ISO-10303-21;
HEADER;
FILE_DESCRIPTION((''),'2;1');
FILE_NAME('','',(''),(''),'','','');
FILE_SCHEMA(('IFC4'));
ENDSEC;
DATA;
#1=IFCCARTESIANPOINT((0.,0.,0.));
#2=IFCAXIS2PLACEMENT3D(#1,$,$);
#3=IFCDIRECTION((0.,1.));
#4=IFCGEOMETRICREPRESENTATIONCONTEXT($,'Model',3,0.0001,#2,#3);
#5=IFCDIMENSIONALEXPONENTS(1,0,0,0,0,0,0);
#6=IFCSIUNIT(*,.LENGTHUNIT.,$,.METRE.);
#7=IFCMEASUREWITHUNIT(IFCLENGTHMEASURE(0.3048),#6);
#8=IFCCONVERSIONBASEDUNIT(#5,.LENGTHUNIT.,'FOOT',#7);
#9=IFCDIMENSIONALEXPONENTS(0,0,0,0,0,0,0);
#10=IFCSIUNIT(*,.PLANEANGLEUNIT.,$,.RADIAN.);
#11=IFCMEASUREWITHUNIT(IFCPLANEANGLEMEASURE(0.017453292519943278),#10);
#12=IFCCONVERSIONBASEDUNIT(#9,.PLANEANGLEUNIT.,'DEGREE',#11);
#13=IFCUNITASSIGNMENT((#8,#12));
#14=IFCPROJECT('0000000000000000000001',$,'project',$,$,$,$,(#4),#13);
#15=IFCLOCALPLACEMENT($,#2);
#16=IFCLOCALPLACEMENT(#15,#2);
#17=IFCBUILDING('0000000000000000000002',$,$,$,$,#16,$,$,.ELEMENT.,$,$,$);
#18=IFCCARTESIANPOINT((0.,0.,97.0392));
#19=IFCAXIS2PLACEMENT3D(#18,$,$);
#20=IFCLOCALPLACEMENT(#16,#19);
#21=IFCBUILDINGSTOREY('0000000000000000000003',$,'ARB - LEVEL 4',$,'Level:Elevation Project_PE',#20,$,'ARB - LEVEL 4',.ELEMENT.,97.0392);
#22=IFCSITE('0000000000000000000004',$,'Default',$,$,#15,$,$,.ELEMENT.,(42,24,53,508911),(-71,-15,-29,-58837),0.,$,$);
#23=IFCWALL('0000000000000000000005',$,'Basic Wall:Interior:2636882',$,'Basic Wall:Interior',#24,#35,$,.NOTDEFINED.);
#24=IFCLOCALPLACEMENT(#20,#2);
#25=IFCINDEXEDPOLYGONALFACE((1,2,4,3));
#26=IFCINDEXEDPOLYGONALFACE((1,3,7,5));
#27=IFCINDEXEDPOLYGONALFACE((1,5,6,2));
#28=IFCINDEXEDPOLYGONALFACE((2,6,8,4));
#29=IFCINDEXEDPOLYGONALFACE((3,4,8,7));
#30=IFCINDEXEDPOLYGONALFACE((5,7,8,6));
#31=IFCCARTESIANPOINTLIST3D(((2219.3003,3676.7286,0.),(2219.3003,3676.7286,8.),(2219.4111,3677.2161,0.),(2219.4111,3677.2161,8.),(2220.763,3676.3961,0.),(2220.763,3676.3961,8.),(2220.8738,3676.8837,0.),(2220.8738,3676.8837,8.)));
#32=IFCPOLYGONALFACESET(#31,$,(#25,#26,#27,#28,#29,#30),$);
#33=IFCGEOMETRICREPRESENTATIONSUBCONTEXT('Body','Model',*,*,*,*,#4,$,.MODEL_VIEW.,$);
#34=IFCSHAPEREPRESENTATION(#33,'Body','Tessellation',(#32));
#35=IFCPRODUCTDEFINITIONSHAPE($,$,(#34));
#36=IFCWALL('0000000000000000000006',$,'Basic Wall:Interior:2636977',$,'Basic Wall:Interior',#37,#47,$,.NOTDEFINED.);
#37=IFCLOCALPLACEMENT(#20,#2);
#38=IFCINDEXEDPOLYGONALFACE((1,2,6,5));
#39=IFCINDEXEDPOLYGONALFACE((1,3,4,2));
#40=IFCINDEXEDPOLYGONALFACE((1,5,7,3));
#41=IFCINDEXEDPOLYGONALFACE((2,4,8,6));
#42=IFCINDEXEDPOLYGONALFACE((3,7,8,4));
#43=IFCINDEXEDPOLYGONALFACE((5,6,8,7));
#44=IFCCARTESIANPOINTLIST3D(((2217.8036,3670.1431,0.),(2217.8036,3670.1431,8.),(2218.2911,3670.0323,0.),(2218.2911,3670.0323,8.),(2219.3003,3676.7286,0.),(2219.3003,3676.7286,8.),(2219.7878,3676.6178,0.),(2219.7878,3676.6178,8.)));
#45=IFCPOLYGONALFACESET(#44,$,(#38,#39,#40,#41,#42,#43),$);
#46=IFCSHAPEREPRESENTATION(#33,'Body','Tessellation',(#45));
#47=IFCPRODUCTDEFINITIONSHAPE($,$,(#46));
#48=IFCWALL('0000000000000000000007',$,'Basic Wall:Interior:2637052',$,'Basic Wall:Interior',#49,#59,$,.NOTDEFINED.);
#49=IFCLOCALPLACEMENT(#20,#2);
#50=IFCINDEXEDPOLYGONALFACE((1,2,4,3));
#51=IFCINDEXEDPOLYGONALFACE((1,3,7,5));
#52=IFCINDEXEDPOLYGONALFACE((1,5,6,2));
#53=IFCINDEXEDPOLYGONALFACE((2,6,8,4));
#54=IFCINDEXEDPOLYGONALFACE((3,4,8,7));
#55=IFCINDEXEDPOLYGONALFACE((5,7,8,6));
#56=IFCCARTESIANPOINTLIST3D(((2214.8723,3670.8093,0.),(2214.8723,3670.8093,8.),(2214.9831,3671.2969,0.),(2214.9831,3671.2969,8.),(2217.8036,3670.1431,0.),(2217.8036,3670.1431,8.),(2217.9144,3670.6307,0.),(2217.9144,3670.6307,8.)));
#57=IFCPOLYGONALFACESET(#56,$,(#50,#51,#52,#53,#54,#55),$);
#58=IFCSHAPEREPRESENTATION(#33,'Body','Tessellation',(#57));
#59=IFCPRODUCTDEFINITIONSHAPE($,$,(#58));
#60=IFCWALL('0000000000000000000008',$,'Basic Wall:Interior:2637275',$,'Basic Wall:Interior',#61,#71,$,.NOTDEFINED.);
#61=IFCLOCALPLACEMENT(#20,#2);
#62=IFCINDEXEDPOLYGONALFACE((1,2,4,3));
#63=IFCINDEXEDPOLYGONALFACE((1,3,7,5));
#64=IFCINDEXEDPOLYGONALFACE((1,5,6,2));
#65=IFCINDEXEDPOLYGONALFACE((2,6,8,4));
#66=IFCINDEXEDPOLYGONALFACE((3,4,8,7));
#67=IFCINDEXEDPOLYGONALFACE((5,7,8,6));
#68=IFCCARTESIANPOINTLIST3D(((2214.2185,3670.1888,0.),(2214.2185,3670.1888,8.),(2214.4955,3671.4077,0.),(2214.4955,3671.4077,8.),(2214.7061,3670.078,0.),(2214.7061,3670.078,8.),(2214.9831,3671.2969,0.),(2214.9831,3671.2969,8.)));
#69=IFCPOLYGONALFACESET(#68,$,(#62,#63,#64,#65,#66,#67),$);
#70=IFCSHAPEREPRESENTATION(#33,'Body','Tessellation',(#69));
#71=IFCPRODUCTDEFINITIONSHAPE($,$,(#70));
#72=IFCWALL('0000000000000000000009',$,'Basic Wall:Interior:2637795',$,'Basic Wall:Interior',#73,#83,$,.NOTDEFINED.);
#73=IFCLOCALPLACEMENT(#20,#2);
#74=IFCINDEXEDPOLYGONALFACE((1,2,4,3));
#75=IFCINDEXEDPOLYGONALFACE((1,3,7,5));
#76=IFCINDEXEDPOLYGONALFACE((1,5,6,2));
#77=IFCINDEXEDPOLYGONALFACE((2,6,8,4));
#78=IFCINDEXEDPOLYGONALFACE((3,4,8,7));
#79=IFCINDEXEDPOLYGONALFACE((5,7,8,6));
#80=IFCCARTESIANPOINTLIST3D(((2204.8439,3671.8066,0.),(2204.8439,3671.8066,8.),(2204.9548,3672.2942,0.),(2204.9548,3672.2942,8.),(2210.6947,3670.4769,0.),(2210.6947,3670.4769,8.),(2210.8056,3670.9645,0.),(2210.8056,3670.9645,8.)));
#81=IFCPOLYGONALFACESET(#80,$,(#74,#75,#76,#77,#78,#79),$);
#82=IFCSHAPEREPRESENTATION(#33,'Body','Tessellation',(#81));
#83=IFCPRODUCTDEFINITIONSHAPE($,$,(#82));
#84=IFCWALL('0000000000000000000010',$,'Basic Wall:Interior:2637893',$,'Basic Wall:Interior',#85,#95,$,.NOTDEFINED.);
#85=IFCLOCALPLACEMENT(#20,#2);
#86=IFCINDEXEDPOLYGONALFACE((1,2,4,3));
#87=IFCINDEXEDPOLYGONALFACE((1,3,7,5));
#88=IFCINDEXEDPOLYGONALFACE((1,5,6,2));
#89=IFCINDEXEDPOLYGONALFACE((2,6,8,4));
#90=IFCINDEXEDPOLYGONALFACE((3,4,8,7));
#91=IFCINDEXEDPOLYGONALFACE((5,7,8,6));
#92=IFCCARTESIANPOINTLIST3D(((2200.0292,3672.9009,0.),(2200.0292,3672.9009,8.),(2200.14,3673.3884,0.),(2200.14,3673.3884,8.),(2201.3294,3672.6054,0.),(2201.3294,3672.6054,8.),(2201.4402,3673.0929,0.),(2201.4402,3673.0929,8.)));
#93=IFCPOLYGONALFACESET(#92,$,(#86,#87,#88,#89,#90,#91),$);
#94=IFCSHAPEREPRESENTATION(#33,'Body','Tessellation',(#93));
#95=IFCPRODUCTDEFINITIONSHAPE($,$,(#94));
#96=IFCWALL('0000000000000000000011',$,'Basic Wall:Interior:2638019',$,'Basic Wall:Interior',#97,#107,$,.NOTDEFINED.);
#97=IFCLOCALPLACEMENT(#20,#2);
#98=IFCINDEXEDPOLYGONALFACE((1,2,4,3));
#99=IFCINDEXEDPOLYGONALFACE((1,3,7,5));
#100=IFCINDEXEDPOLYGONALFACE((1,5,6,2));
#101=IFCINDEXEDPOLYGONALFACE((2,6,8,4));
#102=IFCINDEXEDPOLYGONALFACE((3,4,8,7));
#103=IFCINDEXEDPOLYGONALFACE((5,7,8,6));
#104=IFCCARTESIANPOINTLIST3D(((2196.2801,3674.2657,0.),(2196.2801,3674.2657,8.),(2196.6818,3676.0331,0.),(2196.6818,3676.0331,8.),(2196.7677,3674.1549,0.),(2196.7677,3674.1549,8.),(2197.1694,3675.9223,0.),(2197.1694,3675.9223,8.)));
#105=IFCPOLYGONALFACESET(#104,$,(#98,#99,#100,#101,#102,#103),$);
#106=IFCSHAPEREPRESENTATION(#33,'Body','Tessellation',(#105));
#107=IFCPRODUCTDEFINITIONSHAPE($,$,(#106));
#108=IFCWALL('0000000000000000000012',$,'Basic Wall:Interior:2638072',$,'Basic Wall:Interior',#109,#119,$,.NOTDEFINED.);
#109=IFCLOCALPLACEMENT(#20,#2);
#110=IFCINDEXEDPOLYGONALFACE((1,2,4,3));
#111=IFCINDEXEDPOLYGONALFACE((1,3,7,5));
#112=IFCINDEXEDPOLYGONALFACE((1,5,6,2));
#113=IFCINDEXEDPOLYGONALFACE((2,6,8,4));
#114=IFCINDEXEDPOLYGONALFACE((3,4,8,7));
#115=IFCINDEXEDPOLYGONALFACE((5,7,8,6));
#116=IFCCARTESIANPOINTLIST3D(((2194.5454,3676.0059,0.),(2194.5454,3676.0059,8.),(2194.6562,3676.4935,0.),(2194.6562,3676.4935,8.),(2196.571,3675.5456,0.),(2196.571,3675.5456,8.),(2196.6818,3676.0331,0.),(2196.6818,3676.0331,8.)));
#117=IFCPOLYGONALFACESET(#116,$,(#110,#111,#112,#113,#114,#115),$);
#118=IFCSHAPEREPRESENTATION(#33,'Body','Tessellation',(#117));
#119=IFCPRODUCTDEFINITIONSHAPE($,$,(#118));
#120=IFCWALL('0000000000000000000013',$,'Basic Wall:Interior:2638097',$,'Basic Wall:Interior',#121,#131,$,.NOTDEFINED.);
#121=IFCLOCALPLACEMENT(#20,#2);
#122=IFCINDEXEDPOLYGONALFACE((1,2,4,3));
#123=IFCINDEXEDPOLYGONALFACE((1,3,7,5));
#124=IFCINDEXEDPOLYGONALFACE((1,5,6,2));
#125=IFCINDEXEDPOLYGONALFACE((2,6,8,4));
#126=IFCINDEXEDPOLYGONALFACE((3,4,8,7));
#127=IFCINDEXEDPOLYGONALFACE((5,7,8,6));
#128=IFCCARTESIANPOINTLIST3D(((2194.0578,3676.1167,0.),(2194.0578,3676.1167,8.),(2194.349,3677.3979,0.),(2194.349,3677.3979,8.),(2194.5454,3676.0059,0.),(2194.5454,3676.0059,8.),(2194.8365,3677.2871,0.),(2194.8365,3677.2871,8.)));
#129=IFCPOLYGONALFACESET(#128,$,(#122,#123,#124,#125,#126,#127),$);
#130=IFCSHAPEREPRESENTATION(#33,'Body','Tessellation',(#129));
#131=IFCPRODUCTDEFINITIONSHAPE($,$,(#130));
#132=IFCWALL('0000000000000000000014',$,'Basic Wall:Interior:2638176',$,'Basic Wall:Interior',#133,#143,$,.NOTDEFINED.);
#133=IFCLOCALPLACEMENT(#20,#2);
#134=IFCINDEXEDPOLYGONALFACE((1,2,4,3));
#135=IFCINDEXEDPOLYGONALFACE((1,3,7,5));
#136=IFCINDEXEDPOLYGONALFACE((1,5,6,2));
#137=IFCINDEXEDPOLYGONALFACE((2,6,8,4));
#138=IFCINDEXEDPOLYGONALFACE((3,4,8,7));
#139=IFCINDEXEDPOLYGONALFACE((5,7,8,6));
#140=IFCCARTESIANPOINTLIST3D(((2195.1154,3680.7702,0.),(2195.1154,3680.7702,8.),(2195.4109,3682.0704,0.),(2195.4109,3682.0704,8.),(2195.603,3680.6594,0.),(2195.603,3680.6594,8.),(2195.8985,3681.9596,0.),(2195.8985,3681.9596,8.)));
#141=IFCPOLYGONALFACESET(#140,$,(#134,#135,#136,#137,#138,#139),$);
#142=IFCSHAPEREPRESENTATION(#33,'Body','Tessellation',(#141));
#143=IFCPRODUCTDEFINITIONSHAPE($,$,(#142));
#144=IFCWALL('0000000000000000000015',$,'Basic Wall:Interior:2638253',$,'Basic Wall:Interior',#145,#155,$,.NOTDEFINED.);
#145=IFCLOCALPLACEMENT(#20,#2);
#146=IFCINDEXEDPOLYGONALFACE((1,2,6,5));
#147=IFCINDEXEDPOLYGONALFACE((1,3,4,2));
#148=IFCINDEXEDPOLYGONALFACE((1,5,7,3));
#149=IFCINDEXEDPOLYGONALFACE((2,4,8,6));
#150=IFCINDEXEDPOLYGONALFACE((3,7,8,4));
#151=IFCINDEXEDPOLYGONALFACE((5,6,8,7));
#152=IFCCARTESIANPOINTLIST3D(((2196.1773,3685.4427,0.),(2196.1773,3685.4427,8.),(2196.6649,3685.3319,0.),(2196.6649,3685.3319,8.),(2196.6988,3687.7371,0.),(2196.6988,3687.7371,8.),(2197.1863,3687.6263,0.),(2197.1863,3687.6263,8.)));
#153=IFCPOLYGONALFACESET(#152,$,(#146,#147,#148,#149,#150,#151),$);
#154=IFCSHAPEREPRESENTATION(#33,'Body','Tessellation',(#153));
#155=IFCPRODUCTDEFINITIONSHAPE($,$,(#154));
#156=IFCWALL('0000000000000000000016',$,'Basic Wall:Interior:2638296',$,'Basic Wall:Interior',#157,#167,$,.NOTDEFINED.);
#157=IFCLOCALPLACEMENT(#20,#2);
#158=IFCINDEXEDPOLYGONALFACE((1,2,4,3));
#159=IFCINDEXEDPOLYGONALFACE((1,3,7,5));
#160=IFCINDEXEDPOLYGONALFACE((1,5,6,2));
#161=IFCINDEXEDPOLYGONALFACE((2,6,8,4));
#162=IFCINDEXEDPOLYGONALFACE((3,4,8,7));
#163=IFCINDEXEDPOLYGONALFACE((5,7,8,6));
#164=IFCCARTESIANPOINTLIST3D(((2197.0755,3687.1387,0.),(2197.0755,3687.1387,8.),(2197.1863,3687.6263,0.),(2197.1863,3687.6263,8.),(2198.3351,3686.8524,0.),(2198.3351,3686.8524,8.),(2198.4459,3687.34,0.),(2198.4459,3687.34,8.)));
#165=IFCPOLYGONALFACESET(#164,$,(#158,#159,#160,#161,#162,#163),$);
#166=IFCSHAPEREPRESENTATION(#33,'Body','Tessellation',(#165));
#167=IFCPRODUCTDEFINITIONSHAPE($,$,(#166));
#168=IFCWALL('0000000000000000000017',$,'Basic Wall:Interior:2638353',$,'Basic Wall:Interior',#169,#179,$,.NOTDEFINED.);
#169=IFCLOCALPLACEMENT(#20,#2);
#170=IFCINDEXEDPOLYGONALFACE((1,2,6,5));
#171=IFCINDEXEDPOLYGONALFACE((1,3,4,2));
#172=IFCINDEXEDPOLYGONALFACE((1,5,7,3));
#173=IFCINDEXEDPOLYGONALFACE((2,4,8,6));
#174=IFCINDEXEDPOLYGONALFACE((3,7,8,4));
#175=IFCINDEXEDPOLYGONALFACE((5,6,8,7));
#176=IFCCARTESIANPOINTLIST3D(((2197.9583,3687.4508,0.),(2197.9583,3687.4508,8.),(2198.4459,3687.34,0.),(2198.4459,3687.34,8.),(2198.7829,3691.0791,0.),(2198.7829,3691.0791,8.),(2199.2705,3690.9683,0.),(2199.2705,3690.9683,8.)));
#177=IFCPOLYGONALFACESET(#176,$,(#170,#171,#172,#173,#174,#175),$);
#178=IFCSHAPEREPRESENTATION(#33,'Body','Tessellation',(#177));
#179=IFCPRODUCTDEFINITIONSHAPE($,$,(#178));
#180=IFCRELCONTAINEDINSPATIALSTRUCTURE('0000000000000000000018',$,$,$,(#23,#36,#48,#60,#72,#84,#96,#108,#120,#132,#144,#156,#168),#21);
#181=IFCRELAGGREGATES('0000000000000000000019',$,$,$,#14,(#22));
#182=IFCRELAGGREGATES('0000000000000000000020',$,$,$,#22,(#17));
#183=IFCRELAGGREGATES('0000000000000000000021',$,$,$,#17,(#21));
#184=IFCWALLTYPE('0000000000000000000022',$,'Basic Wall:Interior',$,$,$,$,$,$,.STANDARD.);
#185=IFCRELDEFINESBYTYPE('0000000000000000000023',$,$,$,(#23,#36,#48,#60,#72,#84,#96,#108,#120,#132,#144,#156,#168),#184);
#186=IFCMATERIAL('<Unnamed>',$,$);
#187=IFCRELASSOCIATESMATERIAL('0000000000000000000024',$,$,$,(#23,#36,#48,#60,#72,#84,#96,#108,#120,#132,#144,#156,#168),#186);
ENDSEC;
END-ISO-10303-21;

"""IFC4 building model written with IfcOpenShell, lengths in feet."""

from ifc_helpers import new_model, entity, si_unit, converted_unit, direction, frame, origin, place, context, subcontext, project, spatial, indexed_curve, outline, extrude, material, type_object, element, save


model = new_model("IFC4")

# Units and contexts
model_context = context("Model", 3, precision=0.0001, world=origin(), true_north=direction((0.0, 1.0)))
body_context = subcontext(model_context, "Body", "Model", "MODEL_VIEW")
ifc_project = project(units=[converted_unit("LENGTHUNIT", "FOOT", entity("IfcLengthMeasure", 0.3048), si_unit("LENGTHUNIT", "METRE"), dimensions=[1, 0, 0, 0, 0, 0, 0]), converted_unit("PLANEANGLEUNIT", "DEGREE", entity("IfcPlaneAngleMeasure", 0.017453292519943278), si_unit("PLANEANGLEUNIT", "RADIAN"), dimensions=[0, 0, 0, 0, 0, 0, 0])], contexts=[model_context])

# Site, building, storey
site_placement = place(None, origin())
site = spatial("IfcSite", under=ifc_project, at=site_placement, Name="Default", CompositionType="ELEMENT", RefLatitude=(42, 24, 53, 508911), RefLongitude=(-71, -15, -29, -58837), RefElevation=0.0)
building_placement = place(site_placement, origin())
building = spatial("IfcBuilding", under=site, at=building_placement, CompositionType="ELEMENT")
storey_placement = place(building_placement, frame((0.0, 0.0, 97.0392)))
storey = spatial("IfcBuildingStorey", under=building, at=storey_placement, Name="ARB - LEVEL 4", ObjectType="Level:Elevation Project_PE", LongName="ARB - LEVEL 4", CompositionType="ELEMENT", Elevation=97.0392)

# Walls
ifc_material_1 = material(Name="<Unnamed>")
wall_type = type_object("IfcWallType", Name="Basic Wall:Interior", PredefinedType="STANDARD")
wall_1_placement = place(storey_placement, frame((2220.8184, 3676.6399, 0.0), z_axis=(0.0, 0.0, 1.0), x_axis=(-0.975133, 0.221622, 0.0)))
element("IfcWall", 1, at=wall_1_placement, inside=storey, type_object=wall_type, material=ifc_material_1, Name="Basic Wall:Interior:2636882", ObjectType="Basic Wall:Interior", PredefinedType="NOTDEFINED", context=body_context, shape_type="SweptSolid", body=[
    extrude(outline(indexed_curve([(1.5, 0.25), (0.0, 0.25), (0.0, -0.25), (1.5, -0.25), (1.5, 0.25)], self_intersect=False)), origin(), (0.0, 0.0, 1.0), 8.0),
])
wall_2_placement = place(storey_placement, frame((2219.544, 3676.6732, 0.0), z_axis=(0.0, 0.0, 1.0), x_axis=(-0.221622, -0.975133, 0.0)))
element("IfcWall", 2, at=wall_2_placement, inside=storey, type_object=wall_type, material=ifc_material_1, Name="Basic Wall:Interior:2636977", ObjectType="Basic Wall:Interior", PredefinedType="NOTDEFINED", context=body_context, shape_type="SweptSolid", body=[
    extrude(outline(indexed_curve([(6.7534, 0.25), (0.0, 0.25), (0.0, -0.25), (6.7534, -0.25), (6.7534, 0.25)], self_intersect=False)), origin(), (0.0, 0.0, 1.0), 8.0),
])
wall_3_placement = place(storey_placement, frame((2217.859, 3670.3869, 0.0), z_axis=(0.0, 0.0, 1.0), x_axis=(-0.975133, 0.221622, 0.0)))
element("IfcWall", 3, at=wall_3_placement, inside=storey, type_object=wall_type, material=ifc_material_1, Name="Basic Wall:Interior:2637052", ObjectType="Basic Wall:Interior", PredefinedType="NOTDEFINED", context=body_context, shape_type="SweptSolid", body=[
    extrude(outline(indexed_curve([(3.006, 0.25), (0.0, 0.25), (0.0, -0.25), (3.006, -0.25), (3.006, 0.25)], self_intersect=False)), origin(), (0.0, 0.0, 1.0), 8.0),
])
wall_4_placement = place(storey_placement, frame((2214.7393, 3671.3523, 0.0), z_axis=(0.0, 0.0, 1.0), x_axis=(-0.221622, -0.975133, 0.0)))
element("IfcWall", 4, at=wall_4_placement, inside=storey, type_object=wall_type, material=ifc_material_1, Name="Basic Wall:Interior:2637275", ObjectType="Basic Wall:Interior", PredefinedType="NOTDEFINED", context=body_context, shape_type="SweptSolid", body=[
    extrude(outline(indexed_curve([(1.25, 0.25), (0.0, 0.25), (0.0, -0.25), (1.25, -0.25), (1.25, 0.25)], self_intersect=False)), origin(), (0.0, 0.0, 1.0), 8.0),
])
wall_5_placement = place(storey_placement, frame((2210.7502, 3670.7207, 0.0), z_axis=(0.0, 0.0, 1.0), x_axis=(-0.975133, 0.221622, 0.0)))
element("IfcWall", 5, at=wall_5_placement, inside=storey, type_object=wall_type, material=ifc_material_1, Name="Basic Wall:Interior:2637795", ObjectType="Basic Wall:Interior", PredefinedType="NOTDEFINED", context=body_context, shape_type="SweptSolid", body=[
    extrude(outline(indexed_curve([(6.0, 0.25), (0.0, 0.25), (0.0, -0.25), (6.0, -0.25), (6.0, 0.25)], self_intersect=False)), origin(), (0.0, 0.0, 1.0), 8.0),
])
wall_6_placement = place(storey_placement, frame((2201.3848, 3672.8492, 0.0), z_axis=(0.0, 0.0, 1.0), x_axis=(-0.975133, 0.221622, 0.0)))
element("IfcWall", 6, at=wall_6_placement, inside=storey, type_object=wall_type, material=ifc_material_1, Name="Basic Wall:Interior:2637893", ObjectType="Basic Wall:Interior", PredefinedType="NOTDEFINED", context=body_context, shape_type="SweptSolid", body=[
    extrude(outline(indexed_curve([(1.3333, 0.25), (0.0, 0.25), (0.0, -0.25), (1.3333, -0.25), (1.3333, 0.25)], self_intersect=False)), origin(), (0.0, 0.0, 1.0), 8.0),
])
wall_7_placement = place(storey_placement, frame((2196.5239, 3674.2103, 0.0), z_axis=(0.0, 0.0, 1.0), x_axis=(0.221622, 0.975133, 0.0)))
element("IfcWall", 7, at=wall_7_placement, inside=storey, type_object=wall_type, material=ifc_material_1, Name="Basic Wall:Interior:2638019", ObjectType="Basic Wall:Interior", PredefinedType="NOTDEFINED", context=body_context, shape_type="SweptSolid", body=[
    extrude(outline(indexed_curve([(1.8125, 0.25), (0.0, 0.25), (0.0, -0.25), (1.8125, -0.25), (1.8125, 0.25)], self_intersect=False)), origin(), (0.0, 0.0, 1.0), 8.0),
])
wall_8_placement = place(storey_placement, frame((2196.6264, 3675.7893, 0.0), z_axis=(0.0, 0.0, 1.0), x_axis=(-0.975133, 0.221622, 0.0)))
element("IfcWall", 8, at=wall_8_placement, inside=storey, type_object=wall_type, material=ifc_material_1, Name="Basic Wall:Interior:2638072", ObjectType="Basic Wall:Interior", PredefinedType="NOTDEFINED", context=body_context, shape_type="SweptSolid", body=[
    extrude(outline(indexed_curve([(2.0773, 0.25), (0.0, 0.25), (0.0, -0.25), (2.0773, -0.25), (2.0773, 0.25)], self_intersect=False)), origin(), (0.0, 0.0, 1.0), 8.0),
])
wall_9_placement = place(storey_placement, frame((2194.3016, 3676.0613, 0.0), z_axis=(0.0, 0.0, 1.0), x_axis=(0.221622, 0.975133, 0.0)))
element("IfcWall", 9, at=wall_9_placement, inside=storey, type_object=wall_type, material=ifc_material_1, Name="Basic Wall:Interior:2638097", ObjectType="Basic Wall:Interior", PredefinedType="NOTDEFINED", context=body_context, shape_type="SweptSolid", body=[
    extrude(outline(indexed_curve([(1.3138, 0.25), (0.0, 0.25), (0.0, -0.25), (1.3138, -0.25), (1.3138, 0.25)], self_intersect=False)), origin(), (0.0, 0.0, 1.0), 8.0),
])
wall_10_placement = place(storey_placement, frame((2195.3592, 3680.7148, 0.0), z_axis=(0.0, 0.0, 1.0), x_axis=(0.221622, 0.975133, 0.0)))
element("IfcWall", 10, at=wall_10_placement, inside=storey, type_object=wall_type, material=ifc_material_1, Name="Basic Wall:Interior:2638176", ObjectType="Basic Wall:Interior", PredefinedType="NOTDEFINED", context=body_context, shape_type="SweptSolid", body=[
    extrude(outline(indexed_curve([(1.3333, 0.25), (0.0, 0.25), (0.0, -0.25), (1.3333, -0.25), (1.3333, 0.25)], self_intersect=False)), origin(), (0.0, 0.0, 1.0), 8.0),
])
wall_11_placement = place(storey_placement, frame((2196.4211, 3685.3873, 0.0), z_axis=(0.0, 0.0, 1.0), x_axis=(0.221622, 0.975133, 0.0)))
element("IfcWall", 11, at=wall_11_placement, inside=storey, type_object=wall_type, material=ifc_material_1, Name="Basic Wall:Interior:2638253", ObjectType="Basic Wall:Interior", PredefinedType="NOTDEFINED", context=body_context, shape_type="SweptSolid", body=[
    extrude(outline(indexed_curve([(2.3529, 0.25), (0.0, 0.25), (0.0, -0.25), (2.3529, -0.25), (2.3529, 0.25)], self_intersect=False)), origin(), (0.0, 0.0, 1.0), 8.0),
])
wall_12_placement = place(storey_placement, frame((2197.1309, 3687.3825, 0.0), z_axis=(0.0, 0.0, 1.0), x_axis=(0.975133, -0.221622, 0.0)))
element("IfcWall", 12, at=wall_12_placement, inside=storey, type_object=wall_type, material=ifc_material_1, Name="Basic Wall:Interior:2638296", ObjectType="Basic Wall:Interior", PredefinedType="NOTDEFINED", context=body_context, shape_type="SweptSolid", body=[
    extrude(outline(indexed_curve([(1.2917, 0.25), (0.0, 0.25), (0.0, -0.25), (1.2917, -0.25), (1.2917, 0.25)], self_intersect=False)), origin(), (0.0, 0.0, 1.0), 8.0),
])
wall_13_placement = place(storey_placement, frame((2198.2021, 3687.3954, 0.0), z_axis=(0.0, 0.0, 1.0), x_axis=(0.221622, 0.975133, 0.0)))
element("IfcWall", 13, at=wall_13_placement, inside=storey, type_object=wall_type, material=ifc_material_1, Name="Basic Wall:Interior:2638353", ObjectType="Basic Wall:Interior", PredefinedType="NOTDEFINED", context=body_context, shape_type="SweptSolid", body=[
    extrude(outline(indexed_curve([(3.7208, 0.25), (0.0, 0.25), (0.0, -0.25), (3.7208, -0.25), (3.7208, 0.25)], self_intersect=False)), origin(), (0.0, 0.0, 1.0), 8.0),
])

save(model, "model.ifc")
